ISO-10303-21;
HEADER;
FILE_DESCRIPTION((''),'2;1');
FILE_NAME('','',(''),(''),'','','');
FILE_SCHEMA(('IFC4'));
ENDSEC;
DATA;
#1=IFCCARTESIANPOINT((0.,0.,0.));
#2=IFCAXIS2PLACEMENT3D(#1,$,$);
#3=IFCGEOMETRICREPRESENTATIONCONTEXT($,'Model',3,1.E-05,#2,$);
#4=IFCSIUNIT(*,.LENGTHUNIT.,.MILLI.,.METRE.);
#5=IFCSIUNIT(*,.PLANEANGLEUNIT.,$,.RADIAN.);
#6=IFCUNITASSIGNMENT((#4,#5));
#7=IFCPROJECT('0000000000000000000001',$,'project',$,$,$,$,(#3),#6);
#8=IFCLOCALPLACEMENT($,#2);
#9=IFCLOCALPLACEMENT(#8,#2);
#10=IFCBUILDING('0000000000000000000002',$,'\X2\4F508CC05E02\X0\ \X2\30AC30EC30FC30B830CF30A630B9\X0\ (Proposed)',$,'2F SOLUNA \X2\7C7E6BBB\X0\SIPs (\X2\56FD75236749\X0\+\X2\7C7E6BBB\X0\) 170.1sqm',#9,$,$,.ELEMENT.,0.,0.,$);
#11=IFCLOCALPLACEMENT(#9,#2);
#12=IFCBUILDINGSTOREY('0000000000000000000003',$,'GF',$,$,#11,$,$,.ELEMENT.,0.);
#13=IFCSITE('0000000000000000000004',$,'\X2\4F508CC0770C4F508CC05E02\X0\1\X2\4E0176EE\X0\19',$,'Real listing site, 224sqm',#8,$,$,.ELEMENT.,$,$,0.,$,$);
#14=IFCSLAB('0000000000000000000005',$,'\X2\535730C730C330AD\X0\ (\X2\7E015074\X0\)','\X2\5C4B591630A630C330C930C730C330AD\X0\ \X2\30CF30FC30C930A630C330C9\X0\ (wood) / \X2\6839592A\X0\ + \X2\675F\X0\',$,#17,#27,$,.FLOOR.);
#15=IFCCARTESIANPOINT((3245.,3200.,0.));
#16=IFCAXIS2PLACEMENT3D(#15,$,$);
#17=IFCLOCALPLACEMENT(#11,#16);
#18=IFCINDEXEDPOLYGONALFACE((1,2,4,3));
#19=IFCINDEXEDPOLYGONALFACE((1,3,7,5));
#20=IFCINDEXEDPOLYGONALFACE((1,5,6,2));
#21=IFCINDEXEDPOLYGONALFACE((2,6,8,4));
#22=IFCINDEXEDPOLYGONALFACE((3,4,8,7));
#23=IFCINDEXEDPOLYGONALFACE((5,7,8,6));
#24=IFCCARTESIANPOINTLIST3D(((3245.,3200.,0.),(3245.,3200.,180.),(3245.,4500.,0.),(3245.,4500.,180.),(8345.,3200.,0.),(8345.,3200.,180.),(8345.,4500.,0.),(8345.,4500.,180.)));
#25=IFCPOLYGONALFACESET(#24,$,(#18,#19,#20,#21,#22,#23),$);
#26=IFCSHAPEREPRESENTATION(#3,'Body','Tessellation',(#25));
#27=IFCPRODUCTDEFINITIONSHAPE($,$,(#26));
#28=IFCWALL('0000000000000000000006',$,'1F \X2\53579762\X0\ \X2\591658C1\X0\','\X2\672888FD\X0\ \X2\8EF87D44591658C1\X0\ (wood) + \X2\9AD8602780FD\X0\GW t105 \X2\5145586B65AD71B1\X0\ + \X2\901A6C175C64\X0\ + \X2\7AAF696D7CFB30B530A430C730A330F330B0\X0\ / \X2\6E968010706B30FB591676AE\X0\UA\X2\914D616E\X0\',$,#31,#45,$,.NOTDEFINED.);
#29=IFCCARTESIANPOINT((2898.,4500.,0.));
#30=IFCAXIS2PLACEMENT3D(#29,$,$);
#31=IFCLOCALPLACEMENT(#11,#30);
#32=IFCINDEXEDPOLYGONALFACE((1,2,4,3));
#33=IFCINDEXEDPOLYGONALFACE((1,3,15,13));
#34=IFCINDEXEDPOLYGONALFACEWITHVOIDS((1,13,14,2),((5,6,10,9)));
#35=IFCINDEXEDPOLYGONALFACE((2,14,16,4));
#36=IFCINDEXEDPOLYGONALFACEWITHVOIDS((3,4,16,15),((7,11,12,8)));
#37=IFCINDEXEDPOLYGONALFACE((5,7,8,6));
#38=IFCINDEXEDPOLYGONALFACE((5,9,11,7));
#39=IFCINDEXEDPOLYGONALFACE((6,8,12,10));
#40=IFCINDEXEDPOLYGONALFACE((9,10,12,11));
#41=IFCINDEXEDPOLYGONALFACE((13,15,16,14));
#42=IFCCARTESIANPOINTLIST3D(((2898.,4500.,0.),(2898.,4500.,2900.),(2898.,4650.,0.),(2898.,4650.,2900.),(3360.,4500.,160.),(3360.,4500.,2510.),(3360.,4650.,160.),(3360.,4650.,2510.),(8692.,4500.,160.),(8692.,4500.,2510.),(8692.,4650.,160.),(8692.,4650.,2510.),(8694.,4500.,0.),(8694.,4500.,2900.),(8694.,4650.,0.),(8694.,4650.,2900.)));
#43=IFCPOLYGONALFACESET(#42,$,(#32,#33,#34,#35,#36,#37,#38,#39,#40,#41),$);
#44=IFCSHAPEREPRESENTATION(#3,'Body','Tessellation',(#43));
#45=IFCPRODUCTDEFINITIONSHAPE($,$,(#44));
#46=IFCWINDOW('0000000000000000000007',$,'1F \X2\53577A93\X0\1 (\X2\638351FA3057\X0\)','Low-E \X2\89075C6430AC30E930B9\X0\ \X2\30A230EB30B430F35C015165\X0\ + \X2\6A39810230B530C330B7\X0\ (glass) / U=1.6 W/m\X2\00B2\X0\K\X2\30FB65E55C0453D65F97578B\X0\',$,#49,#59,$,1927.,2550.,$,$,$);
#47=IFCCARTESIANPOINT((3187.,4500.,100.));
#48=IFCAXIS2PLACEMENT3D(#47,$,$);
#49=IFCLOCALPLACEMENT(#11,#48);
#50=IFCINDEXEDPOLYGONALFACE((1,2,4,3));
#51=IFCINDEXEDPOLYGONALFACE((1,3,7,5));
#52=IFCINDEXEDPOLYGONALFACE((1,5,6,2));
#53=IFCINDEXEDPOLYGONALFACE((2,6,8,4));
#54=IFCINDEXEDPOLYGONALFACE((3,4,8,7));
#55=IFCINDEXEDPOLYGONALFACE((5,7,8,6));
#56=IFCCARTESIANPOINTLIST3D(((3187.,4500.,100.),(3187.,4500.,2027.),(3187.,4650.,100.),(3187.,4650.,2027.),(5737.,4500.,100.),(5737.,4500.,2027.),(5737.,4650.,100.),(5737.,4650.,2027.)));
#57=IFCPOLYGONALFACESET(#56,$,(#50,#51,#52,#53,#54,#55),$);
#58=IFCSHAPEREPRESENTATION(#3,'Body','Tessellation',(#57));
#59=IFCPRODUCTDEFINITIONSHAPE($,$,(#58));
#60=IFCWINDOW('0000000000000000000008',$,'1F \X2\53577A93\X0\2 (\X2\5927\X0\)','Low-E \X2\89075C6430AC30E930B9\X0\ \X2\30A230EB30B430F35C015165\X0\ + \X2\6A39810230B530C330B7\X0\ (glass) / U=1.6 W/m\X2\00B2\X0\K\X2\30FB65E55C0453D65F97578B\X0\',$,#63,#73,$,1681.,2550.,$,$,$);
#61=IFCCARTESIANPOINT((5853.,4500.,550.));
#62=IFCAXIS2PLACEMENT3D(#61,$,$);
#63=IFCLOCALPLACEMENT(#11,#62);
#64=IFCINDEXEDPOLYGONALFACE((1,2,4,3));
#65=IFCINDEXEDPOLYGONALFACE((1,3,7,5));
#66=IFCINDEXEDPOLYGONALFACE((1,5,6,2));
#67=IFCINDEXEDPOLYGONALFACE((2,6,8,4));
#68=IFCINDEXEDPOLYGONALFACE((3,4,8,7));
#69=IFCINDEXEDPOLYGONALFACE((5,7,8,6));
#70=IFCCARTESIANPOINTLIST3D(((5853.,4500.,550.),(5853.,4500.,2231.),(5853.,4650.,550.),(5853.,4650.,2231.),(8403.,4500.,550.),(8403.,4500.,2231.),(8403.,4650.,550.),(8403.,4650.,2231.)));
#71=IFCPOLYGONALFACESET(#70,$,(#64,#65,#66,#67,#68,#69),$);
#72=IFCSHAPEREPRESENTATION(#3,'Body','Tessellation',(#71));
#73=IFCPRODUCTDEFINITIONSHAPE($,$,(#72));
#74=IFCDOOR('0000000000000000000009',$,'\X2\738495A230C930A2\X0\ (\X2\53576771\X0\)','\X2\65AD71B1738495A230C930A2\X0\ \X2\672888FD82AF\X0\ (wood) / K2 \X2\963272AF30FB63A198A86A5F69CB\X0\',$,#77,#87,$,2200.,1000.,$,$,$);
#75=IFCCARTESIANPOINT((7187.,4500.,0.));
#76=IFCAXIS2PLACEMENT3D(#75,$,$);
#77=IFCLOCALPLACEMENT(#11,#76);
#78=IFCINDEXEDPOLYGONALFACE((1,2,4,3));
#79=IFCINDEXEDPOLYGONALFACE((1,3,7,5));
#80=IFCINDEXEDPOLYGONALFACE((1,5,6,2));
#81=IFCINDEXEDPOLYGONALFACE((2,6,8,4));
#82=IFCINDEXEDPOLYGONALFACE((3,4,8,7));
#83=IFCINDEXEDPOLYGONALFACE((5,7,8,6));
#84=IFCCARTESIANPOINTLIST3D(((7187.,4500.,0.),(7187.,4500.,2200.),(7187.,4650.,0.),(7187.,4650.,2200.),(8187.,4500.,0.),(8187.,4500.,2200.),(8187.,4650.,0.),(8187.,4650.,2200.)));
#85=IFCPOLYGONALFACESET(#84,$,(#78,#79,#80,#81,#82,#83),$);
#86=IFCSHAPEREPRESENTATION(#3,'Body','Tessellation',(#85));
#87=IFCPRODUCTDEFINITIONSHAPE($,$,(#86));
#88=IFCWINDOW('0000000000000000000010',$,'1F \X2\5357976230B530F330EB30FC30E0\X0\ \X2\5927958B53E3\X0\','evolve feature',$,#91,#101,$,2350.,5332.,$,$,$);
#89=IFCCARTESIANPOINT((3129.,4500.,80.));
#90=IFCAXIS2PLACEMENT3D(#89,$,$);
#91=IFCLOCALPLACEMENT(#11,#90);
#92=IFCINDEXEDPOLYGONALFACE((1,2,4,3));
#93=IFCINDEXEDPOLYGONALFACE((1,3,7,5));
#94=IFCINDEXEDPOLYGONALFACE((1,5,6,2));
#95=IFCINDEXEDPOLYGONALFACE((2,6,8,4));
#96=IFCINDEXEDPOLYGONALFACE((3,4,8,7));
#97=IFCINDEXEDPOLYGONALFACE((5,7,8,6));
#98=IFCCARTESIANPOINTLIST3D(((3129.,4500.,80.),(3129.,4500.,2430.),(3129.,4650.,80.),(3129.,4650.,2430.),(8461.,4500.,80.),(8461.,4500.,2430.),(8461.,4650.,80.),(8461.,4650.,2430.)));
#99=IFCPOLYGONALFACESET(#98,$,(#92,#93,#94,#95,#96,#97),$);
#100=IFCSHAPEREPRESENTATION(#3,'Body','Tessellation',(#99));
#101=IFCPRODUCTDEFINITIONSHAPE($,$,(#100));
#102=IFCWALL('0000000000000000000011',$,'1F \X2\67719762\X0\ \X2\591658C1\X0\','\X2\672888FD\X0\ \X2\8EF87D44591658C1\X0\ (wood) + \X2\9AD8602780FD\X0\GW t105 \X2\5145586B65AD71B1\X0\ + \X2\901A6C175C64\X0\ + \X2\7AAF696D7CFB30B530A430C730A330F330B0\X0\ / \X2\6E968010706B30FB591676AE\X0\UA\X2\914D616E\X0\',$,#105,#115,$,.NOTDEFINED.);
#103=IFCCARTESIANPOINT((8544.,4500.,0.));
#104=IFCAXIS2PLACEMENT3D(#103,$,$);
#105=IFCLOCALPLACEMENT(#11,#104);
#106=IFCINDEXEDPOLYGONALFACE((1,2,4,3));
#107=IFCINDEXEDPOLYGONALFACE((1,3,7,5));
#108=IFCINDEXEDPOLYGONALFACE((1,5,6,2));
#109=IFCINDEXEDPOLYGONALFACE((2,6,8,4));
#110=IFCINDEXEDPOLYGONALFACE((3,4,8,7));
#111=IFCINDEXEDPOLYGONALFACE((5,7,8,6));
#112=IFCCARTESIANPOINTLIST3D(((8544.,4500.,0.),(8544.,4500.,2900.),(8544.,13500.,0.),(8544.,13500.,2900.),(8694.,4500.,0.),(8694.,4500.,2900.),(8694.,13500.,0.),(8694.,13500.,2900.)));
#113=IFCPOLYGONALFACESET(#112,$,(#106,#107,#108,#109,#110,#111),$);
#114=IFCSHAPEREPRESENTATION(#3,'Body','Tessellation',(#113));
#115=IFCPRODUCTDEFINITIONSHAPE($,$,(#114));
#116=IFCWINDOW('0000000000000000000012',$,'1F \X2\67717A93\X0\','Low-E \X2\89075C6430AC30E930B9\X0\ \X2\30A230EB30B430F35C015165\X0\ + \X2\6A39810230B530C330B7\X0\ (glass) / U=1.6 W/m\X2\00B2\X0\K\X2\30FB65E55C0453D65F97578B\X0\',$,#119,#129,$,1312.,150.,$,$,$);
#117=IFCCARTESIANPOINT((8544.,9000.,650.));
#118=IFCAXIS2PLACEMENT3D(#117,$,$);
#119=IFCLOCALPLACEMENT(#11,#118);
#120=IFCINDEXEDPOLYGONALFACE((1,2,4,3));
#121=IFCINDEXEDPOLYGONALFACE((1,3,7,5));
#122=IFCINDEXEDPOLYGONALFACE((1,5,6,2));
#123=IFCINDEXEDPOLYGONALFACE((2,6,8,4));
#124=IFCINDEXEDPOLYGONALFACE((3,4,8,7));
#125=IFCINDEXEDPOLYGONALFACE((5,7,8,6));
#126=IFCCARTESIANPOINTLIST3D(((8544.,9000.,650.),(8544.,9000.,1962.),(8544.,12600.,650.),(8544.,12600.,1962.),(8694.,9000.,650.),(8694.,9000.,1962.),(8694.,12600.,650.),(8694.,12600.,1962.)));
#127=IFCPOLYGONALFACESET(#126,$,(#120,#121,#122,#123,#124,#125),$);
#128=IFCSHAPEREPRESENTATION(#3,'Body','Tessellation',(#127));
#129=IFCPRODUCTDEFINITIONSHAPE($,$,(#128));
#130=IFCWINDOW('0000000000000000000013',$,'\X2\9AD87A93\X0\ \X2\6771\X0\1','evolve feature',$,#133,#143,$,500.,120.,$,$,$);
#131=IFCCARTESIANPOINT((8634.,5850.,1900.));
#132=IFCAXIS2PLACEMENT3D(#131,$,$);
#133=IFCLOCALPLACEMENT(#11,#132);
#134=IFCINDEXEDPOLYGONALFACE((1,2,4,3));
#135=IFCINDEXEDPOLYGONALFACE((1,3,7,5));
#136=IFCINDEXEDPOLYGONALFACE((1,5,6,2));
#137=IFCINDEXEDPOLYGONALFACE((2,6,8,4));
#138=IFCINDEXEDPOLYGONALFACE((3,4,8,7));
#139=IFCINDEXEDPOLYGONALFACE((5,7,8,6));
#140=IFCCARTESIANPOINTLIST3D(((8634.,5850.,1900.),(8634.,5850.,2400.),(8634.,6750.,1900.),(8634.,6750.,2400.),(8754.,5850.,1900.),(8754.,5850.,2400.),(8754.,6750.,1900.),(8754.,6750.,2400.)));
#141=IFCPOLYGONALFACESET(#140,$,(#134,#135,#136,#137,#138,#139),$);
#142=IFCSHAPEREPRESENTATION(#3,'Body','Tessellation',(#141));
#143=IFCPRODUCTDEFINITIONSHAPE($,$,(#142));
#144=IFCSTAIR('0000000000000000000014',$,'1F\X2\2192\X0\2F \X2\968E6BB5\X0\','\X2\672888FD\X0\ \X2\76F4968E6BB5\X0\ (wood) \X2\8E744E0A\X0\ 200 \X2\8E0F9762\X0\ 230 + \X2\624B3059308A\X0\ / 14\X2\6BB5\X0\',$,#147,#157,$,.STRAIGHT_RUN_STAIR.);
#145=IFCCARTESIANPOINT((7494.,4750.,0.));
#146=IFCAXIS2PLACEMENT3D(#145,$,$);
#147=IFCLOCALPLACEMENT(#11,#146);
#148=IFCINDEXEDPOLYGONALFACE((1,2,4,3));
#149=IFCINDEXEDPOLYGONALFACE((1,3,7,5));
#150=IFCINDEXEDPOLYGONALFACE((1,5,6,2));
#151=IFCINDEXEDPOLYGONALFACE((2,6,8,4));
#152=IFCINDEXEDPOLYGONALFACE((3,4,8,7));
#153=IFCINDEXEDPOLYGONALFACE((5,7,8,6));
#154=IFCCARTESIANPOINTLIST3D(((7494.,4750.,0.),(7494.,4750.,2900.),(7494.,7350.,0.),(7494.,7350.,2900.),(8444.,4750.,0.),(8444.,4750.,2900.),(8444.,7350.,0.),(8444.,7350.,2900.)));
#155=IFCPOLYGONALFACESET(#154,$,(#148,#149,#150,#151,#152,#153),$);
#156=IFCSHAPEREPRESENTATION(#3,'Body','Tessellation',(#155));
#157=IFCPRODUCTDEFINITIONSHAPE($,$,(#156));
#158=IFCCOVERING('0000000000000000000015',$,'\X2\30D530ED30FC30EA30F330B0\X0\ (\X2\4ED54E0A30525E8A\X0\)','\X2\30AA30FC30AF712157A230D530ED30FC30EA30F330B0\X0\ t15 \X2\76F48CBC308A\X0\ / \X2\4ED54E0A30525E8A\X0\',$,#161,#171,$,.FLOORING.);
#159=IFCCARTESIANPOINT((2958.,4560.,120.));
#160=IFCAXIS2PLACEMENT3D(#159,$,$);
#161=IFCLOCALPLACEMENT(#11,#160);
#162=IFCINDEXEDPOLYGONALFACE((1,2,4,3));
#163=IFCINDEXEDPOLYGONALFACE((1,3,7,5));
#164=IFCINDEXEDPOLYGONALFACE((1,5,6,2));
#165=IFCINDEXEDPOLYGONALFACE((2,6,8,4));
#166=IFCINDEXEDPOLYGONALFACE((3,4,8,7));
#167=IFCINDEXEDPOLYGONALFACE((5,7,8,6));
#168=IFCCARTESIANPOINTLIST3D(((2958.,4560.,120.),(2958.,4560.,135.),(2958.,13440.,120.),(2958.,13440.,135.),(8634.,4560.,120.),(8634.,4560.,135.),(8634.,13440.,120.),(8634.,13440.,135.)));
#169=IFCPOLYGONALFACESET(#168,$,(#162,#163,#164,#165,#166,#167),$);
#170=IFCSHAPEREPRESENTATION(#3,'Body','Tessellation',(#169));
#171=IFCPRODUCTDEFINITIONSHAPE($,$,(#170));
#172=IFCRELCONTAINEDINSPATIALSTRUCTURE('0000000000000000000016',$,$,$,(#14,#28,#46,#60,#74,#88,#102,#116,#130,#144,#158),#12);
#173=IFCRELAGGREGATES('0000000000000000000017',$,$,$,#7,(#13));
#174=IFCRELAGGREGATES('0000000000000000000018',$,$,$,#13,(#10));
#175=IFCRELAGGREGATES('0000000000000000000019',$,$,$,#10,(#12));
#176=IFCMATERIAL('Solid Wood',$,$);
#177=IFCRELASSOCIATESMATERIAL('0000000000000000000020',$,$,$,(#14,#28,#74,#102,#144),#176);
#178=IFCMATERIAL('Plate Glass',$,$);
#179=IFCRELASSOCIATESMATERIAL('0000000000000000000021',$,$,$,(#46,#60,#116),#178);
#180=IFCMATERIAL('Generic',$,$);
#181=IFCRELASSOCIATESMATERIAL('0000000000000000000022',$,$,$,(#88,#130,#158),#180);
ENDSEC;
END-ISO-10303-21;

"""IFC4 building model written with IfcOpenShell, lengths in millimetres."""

from ifc_helpers import new_model, si_unit, frame, frame_2d, origin, place, context, project, spatial, rectangle, extrude, material, element, fill, save


model = new_model("IFC4")

# Units and contexts
model_context = context("Model", 3, precision=1e-05, world=origin())
ifc_project = project(units=[si_unit("LENGTHUNIT", "METRE", prefix="MILLI"), si_unit("PLANEANGLEUNIT", "RADIAN")], contexts=[model_context])

# Site, building, storey
site_placement = place(None, origin())
site = spatial("IfcSite", under=ifc_project, at=site_placement, Name="佐賀県佐賀市1丁目19", ObjectType="Real listing site, 224sqm", CompositionType="ELEMENT", RefElevation=0.0)
building_placement = place(site_placement, origin())
building = spatial("IfcBuilding", under=site, at=building_placement, Name="佐賀市 ガレージハウス (Proposed)", ObjectType="2F SOLUNA 籾殻SIPs (国産杉+籾殻) 170.1sqm", CompositionType="ELEMENT", ElevationOfRefHeight=0.0, ElevationOfTerrain=0.0)
storey_placement = place(building_placement, origin())
storey = spatial("IfcBuildingStorey", under=building, at=storey_placement, Name="GF", CompositionType="ELEMENT", Elevation=0.0)

# Slab
ifc_material_1 = material(Name="Solid Wood")
slab_1_placement = place(storey_placement, frame((3245.0, 3200.0, 0.0)))
element("IfcSlab", 1, at=slab_1_placement, inside=storey, material=ifc_material_1, Name="南デッキ (縁側)", Description="屋外ウッドデッキ ハードウッド (wood) / 根太 + 束", PredefinedType="FLOOR", context=model_context, shape_type="SweptSolid", body=[
    extrude(rectangle(XDim=5100.0, YDim=1300.0, at=frame_2d((2550.0, 650.0))), frame((3245.0, 3200.0, 0.0)), (0.0, 0.0, 1.0), 180.0),
])
ifc_material_2 = material(Name="Generic")

# Wall, openings, windows, door
wall_1_placement = place(storey_placement, frame((2898.0, 4500.0, 0.0)))
wall_1 = element("IfcWall", 2, at=wall_1_placement, inside=storey, material=ifc_material_1, Name="1F 南面 外壁", Description="木製 軸組外壁 (wood) + 高性能GW t105 充填断熱 + 通気層 + 窯業系サイディング / 準耐火・外皮UA配慮", PredefinedType="NOTDEFINED", context=model_context, shape_type="SweptSolid", body=[
    extrude(rectangle(XDim=5796.0, YDim=150.0, at=frame_2d((2898.0, 75.0))), frame((2898.0, 4500.0, 0.0)), (0.0, 0.0, 1.0), 2900.0),
])
opening_1_placement = place(storey_placement, frame((3187.0, 4500.0, 100.0)))
opening_1 = element("IfcOpeningElement", 3, at=opening_1_placement, cuts=wall_1, PredefinedType="NOTDEFINED", context=model_context, shape_type="SweptSolid", body=[
    extrude(rectangle(XDim=2550.0, YDim=150.0, at=frame_2d((1275.0, 75.0))), frame((3187.0, 4500.0, 100.0)), (0.0, 0.0, 1.0), 1927.0),
])
opening_2_placement = place(storey_placement, frame((5853.0, 4500.0, 550.0)))
opening_2 = element("IfcOpeningElement", 4, at=opening_2_placement, cuts=wall_1, PredefinedType="NOTDEFINED", context=model_context, shape_type="SweptSolid", body=[
    extrude(rectangle(XDim=2550.0, YDim=150.0, at=frame_2d((1275.0, 75.0))), frame((5853.0, 4500.0, 550.0)), (0.0, 0.0, 1.0), 1681.0),
])
opening_3_placement = place(storey_placement, frame((7187.0, 4500.0, 0.0)))
opening_3 = element("IfcOpeningElement", 5, at=opening_3_placement, cuts=wall_1, PredefinedType="NOTDEFINED", context=model_context, shape_type="SweptSolid", body=[
    extrude(rectangle(XDim=1000.0, YDim=150.0, at=frame_2d((500.0, 75.0))), frame((7187.0, 4500.0, 0.0)), (0.0, 0.0, 1.0), 2200.0),
])
opening_4_placement = place(storey_placement, frame((3129.0, 4500.0, 80.0)))
opening_4 = element("IfcOpeningElement", 6, at=opening_4_placement, cuts=wall_1, PredefinedType="NOTDEFINED", context=model_context, shape_type="SweptSolid", body=[
    extrude(rectangle(XDim=5332.0, YDim=150.0, at=frame_2d((2666.0, 75.0))), frame((3129.0, 4500.0, 80.0)), (0.0, 0.0, 1.0), 2350.0),
])
ifc_material_3 = material(Name="Plate Glass")
window_1_placement = place(storey_placement, frame((3187.0, 4500.0, 100.0)))
window_1 = element("IfcWindow", 7, at=window_1_placement, inside=storey, material=ifc_material_3, Name="1F 南窓1 (掃出し)", Description="Low-E 複層ガラス アルゴン封入 + 樹脂サッシ (glass) / U=1.6 W/m²K・日射取得型", OverallHeight=1927.0, OverallWidth=2550.0, context=model_context, shape_type="SweptSolid", body=[
    extrude(rectangle(XDim=2550.0, YDim=150.0, at=frame_2d((1275.0, 75.0))), frame((3187.0, 4500.0, 100.0)), (0.0, 0.0, 1.0), 1927.0),
])
fill(opening_1, window_1)
window_2_placement = place(storey_placement, frame((5853.0, 4500.0, 550.0)))
window_2 = element("IfcWindow", 8, at=window_2_placement, inside=storey, material=ifc_material_3, Name="1F 南窓2 (大)", Description="Low-E 複層ガラス アルゴン封入 + 樹脂サッシ (glass) / U=1.6 W/m²K・日射取得型", OverallHeight=1681.0, OverallWidth=2550.0, context=model_context, shape_type="SweptSolid", body=[
    extrude(rectangle(XDim=2550.0, YDim=150.0, at=frame_2d((1275.0, 75.0))), frame((5853.0, 4500.0, 550.0)), (0.0, 0.0, 1.0), 1681.0),
])
fill(opening_2, window_2)
door_placement = place(storey_placement, frame((7187.0, 4500.0, 0.0)))
door = element("IfcDoor", 9, at=door_placement, inside=storey, material=ifc_material_1, Name="玄関ドア (南東)", Description="断熱玄関ドア 木製芯 (wood) / K2 防犯・採風機構", OverallHeight=2200.0, OverallWidth=1000.0, context=model_context, shape_type="SweptSolid", body=[
    extrude(rectangle(XDim=1000.0, YDim=150.0, at=frame_2d((500.0, 75.0))), frame((7187.0, 4500.0, 0.0)), (0.0, 0.0, 1.0), 2200.0),
])
fill(opening_3, door)
window_3_placement = place(storey_placement, frame((3129.0, 4500.0, 80.0)))
window_3 = element("IfcWindow", 10, at=window_3_placement, inside=storey, material=ifc_material_2, Name="1F 南面サンルーム 大開口", Description="evolve feature", OverallHeight=2350.0, OverallWidth=5332.0, context=model_context, shape_type="SweptSolid", body=[
    extrude(rectangle(XDim=5332.0, YDim=150.0, at=frame_2d((2666.0, 75.0))), frame((3129.0, 4500.0, 80.0)), (0.0, 0.0, 1.0), 2350.0),
])
fill(opening_4, window_3)

# Wall, openings, windows
wall_2_placement = place(storey_placement, frame((8544.0, 4500.0, 0.0)))
wall_2 = element("IfcWall", 11, at=wall_2_placement, inside=storey, material=ifc_material_1, Name="1F 東面 外壁", Description="木製 軸組外壁 (wood) + 高性能GW t105 充填断熱 + 通気層 + 窯業系サイディング / 準耐火・外皮UA配慮", PredefinedType="NOTDEFINED", context=model_context, shape_type="SweptSolid", body=[
    extrude(rectangle(XDim=150.0, YDim=9000.0, at=frame_2d((75.0, 4500.0))), frame((8544.0, 4500.0, 0.0)), (0.0, 0.0, 1.0), 2900.0),
])
opening_5_placement = place(storey_placement, frame((8544.0, 9000.0, 650.0)))
opening_5 = element("IfcOpeningElement", 12, at=opening_5_placement, cuts=wall_2, PredefinedType="NOTDEFINED", context=model_context, shape_type="SweptSolid", body=[
    extrude(rectangle(XDim=150.0, YDim=3600.0, at=frame_2d((75.0, 1800.0))), frame((8544.0, 9000.0, 650.0)), (0.0, 0.0, 1.0), 1312.0),
])
opening_6_placement = place(storey_placement, frame((8634.0, 5850.0, 1900.0)))
opening_6 = element("IfcOpeningElement", 13, at=opening_6_placement, cuts=wall_2, PredefinedType="NOTDEFINED", context=model_context, shape_type="SweptSolid", body=[
    extrude(rectangle(XDim=120.0, YDim=900.0, at=frame_2d((60.0, 450.0))), frame((8634.0, 5850.0, 1900.0)), (0.0, 0.0, 1.0), 500.0),
])
window_4_placement = place(storey_placement, frame((8544.0, 9000.0, 650.0)))
window_4 = element("IfcWindow", 14, at=window_4_placement, inside=storey, material=ifc_material_3, Name="1F 東窓", Description="Low-E 複層ガラス アルゴン封入 + 樹脂サッシ (glass) / U=1.6 W/m²K・日射取得型", OverallHeight=1312.0, OverallWidth=150.0, context=model_context, shape_type="SweptSolid", body=[
    extrude(rectangle(XDim=150.0, YDim=3600.0, at=frame_2d((75.0, 1800.0))), frame((8544.0, 9000.0, 650.0)), (0.0, 0.0, 1.0), 1312.0),
])
fill(opening_5, window_4)
window_5_placement = place(storey_placement, frame((8634.0, 5850.0, 1900.0)))
window_5 = element("IfcWindow", 15, at=window_5_placement, inside=storey, material=ifc_material_2, Name="高窓 東1", Description="evolve feature", OverallHeight=500.0, OverallWidth=120.0, context=model_context, shape_type="SweptSolid", body=[
    extrude(rectangle(XDim=120.0, YDim=900.0, at=frame_2d((60.0, 450.0))), frame((8634.0, 5850.0, 1900.0)), (0.0, 0.0, 1.0), 500.0),
])
fill(opening_6, window_5)

# Stair
stair_placement = place(storey_placement, frame((7494.0, 4750.0, 0.0)))
element("IfcStair", 16, at=stair_placement, inside=storey, material=ifc_material_1, Name="1F→2F 階段", Description="木製 直階段 (wood) 蹴上 200 踏面 230 + 手すり / 14段", PredefinedType="STRAIGHT_RUN_STAIR", context=model_context, shape_type="SweptSolid", body=[
    extrude(rectangle(XDim=950.0, YDim=2600.0, at=frame_2d((475.0, 1300.0))), frame((7494.0, 4750.0, 0.0)), (0.0, 0.0, 1.0), 2900.0),
])

# Covering
covering_placement = place(storey_placement, frame((2958.0, 4560.0, 120.0)))
element("IfcCovering", 17, at=covering_placement, inside=storey, material=ifc_material_2, Name="フローリング (仕上げ床)", Description="オーク無垢フローリング t15 直貼り / 仕上げ床", PredefinedType="FLOORING", context=model_context, shape_type="SweptSolid", body=[
    extrude(rectangle(XDim=5676.0, YDim=8880.0, at=frame_2d((2838.0, 4440.0))), frame((2958.0, 4560.0, 120.0)), (0.0, 0.0, 1.0), 15.0),
])

save(model, "model.ifc")
